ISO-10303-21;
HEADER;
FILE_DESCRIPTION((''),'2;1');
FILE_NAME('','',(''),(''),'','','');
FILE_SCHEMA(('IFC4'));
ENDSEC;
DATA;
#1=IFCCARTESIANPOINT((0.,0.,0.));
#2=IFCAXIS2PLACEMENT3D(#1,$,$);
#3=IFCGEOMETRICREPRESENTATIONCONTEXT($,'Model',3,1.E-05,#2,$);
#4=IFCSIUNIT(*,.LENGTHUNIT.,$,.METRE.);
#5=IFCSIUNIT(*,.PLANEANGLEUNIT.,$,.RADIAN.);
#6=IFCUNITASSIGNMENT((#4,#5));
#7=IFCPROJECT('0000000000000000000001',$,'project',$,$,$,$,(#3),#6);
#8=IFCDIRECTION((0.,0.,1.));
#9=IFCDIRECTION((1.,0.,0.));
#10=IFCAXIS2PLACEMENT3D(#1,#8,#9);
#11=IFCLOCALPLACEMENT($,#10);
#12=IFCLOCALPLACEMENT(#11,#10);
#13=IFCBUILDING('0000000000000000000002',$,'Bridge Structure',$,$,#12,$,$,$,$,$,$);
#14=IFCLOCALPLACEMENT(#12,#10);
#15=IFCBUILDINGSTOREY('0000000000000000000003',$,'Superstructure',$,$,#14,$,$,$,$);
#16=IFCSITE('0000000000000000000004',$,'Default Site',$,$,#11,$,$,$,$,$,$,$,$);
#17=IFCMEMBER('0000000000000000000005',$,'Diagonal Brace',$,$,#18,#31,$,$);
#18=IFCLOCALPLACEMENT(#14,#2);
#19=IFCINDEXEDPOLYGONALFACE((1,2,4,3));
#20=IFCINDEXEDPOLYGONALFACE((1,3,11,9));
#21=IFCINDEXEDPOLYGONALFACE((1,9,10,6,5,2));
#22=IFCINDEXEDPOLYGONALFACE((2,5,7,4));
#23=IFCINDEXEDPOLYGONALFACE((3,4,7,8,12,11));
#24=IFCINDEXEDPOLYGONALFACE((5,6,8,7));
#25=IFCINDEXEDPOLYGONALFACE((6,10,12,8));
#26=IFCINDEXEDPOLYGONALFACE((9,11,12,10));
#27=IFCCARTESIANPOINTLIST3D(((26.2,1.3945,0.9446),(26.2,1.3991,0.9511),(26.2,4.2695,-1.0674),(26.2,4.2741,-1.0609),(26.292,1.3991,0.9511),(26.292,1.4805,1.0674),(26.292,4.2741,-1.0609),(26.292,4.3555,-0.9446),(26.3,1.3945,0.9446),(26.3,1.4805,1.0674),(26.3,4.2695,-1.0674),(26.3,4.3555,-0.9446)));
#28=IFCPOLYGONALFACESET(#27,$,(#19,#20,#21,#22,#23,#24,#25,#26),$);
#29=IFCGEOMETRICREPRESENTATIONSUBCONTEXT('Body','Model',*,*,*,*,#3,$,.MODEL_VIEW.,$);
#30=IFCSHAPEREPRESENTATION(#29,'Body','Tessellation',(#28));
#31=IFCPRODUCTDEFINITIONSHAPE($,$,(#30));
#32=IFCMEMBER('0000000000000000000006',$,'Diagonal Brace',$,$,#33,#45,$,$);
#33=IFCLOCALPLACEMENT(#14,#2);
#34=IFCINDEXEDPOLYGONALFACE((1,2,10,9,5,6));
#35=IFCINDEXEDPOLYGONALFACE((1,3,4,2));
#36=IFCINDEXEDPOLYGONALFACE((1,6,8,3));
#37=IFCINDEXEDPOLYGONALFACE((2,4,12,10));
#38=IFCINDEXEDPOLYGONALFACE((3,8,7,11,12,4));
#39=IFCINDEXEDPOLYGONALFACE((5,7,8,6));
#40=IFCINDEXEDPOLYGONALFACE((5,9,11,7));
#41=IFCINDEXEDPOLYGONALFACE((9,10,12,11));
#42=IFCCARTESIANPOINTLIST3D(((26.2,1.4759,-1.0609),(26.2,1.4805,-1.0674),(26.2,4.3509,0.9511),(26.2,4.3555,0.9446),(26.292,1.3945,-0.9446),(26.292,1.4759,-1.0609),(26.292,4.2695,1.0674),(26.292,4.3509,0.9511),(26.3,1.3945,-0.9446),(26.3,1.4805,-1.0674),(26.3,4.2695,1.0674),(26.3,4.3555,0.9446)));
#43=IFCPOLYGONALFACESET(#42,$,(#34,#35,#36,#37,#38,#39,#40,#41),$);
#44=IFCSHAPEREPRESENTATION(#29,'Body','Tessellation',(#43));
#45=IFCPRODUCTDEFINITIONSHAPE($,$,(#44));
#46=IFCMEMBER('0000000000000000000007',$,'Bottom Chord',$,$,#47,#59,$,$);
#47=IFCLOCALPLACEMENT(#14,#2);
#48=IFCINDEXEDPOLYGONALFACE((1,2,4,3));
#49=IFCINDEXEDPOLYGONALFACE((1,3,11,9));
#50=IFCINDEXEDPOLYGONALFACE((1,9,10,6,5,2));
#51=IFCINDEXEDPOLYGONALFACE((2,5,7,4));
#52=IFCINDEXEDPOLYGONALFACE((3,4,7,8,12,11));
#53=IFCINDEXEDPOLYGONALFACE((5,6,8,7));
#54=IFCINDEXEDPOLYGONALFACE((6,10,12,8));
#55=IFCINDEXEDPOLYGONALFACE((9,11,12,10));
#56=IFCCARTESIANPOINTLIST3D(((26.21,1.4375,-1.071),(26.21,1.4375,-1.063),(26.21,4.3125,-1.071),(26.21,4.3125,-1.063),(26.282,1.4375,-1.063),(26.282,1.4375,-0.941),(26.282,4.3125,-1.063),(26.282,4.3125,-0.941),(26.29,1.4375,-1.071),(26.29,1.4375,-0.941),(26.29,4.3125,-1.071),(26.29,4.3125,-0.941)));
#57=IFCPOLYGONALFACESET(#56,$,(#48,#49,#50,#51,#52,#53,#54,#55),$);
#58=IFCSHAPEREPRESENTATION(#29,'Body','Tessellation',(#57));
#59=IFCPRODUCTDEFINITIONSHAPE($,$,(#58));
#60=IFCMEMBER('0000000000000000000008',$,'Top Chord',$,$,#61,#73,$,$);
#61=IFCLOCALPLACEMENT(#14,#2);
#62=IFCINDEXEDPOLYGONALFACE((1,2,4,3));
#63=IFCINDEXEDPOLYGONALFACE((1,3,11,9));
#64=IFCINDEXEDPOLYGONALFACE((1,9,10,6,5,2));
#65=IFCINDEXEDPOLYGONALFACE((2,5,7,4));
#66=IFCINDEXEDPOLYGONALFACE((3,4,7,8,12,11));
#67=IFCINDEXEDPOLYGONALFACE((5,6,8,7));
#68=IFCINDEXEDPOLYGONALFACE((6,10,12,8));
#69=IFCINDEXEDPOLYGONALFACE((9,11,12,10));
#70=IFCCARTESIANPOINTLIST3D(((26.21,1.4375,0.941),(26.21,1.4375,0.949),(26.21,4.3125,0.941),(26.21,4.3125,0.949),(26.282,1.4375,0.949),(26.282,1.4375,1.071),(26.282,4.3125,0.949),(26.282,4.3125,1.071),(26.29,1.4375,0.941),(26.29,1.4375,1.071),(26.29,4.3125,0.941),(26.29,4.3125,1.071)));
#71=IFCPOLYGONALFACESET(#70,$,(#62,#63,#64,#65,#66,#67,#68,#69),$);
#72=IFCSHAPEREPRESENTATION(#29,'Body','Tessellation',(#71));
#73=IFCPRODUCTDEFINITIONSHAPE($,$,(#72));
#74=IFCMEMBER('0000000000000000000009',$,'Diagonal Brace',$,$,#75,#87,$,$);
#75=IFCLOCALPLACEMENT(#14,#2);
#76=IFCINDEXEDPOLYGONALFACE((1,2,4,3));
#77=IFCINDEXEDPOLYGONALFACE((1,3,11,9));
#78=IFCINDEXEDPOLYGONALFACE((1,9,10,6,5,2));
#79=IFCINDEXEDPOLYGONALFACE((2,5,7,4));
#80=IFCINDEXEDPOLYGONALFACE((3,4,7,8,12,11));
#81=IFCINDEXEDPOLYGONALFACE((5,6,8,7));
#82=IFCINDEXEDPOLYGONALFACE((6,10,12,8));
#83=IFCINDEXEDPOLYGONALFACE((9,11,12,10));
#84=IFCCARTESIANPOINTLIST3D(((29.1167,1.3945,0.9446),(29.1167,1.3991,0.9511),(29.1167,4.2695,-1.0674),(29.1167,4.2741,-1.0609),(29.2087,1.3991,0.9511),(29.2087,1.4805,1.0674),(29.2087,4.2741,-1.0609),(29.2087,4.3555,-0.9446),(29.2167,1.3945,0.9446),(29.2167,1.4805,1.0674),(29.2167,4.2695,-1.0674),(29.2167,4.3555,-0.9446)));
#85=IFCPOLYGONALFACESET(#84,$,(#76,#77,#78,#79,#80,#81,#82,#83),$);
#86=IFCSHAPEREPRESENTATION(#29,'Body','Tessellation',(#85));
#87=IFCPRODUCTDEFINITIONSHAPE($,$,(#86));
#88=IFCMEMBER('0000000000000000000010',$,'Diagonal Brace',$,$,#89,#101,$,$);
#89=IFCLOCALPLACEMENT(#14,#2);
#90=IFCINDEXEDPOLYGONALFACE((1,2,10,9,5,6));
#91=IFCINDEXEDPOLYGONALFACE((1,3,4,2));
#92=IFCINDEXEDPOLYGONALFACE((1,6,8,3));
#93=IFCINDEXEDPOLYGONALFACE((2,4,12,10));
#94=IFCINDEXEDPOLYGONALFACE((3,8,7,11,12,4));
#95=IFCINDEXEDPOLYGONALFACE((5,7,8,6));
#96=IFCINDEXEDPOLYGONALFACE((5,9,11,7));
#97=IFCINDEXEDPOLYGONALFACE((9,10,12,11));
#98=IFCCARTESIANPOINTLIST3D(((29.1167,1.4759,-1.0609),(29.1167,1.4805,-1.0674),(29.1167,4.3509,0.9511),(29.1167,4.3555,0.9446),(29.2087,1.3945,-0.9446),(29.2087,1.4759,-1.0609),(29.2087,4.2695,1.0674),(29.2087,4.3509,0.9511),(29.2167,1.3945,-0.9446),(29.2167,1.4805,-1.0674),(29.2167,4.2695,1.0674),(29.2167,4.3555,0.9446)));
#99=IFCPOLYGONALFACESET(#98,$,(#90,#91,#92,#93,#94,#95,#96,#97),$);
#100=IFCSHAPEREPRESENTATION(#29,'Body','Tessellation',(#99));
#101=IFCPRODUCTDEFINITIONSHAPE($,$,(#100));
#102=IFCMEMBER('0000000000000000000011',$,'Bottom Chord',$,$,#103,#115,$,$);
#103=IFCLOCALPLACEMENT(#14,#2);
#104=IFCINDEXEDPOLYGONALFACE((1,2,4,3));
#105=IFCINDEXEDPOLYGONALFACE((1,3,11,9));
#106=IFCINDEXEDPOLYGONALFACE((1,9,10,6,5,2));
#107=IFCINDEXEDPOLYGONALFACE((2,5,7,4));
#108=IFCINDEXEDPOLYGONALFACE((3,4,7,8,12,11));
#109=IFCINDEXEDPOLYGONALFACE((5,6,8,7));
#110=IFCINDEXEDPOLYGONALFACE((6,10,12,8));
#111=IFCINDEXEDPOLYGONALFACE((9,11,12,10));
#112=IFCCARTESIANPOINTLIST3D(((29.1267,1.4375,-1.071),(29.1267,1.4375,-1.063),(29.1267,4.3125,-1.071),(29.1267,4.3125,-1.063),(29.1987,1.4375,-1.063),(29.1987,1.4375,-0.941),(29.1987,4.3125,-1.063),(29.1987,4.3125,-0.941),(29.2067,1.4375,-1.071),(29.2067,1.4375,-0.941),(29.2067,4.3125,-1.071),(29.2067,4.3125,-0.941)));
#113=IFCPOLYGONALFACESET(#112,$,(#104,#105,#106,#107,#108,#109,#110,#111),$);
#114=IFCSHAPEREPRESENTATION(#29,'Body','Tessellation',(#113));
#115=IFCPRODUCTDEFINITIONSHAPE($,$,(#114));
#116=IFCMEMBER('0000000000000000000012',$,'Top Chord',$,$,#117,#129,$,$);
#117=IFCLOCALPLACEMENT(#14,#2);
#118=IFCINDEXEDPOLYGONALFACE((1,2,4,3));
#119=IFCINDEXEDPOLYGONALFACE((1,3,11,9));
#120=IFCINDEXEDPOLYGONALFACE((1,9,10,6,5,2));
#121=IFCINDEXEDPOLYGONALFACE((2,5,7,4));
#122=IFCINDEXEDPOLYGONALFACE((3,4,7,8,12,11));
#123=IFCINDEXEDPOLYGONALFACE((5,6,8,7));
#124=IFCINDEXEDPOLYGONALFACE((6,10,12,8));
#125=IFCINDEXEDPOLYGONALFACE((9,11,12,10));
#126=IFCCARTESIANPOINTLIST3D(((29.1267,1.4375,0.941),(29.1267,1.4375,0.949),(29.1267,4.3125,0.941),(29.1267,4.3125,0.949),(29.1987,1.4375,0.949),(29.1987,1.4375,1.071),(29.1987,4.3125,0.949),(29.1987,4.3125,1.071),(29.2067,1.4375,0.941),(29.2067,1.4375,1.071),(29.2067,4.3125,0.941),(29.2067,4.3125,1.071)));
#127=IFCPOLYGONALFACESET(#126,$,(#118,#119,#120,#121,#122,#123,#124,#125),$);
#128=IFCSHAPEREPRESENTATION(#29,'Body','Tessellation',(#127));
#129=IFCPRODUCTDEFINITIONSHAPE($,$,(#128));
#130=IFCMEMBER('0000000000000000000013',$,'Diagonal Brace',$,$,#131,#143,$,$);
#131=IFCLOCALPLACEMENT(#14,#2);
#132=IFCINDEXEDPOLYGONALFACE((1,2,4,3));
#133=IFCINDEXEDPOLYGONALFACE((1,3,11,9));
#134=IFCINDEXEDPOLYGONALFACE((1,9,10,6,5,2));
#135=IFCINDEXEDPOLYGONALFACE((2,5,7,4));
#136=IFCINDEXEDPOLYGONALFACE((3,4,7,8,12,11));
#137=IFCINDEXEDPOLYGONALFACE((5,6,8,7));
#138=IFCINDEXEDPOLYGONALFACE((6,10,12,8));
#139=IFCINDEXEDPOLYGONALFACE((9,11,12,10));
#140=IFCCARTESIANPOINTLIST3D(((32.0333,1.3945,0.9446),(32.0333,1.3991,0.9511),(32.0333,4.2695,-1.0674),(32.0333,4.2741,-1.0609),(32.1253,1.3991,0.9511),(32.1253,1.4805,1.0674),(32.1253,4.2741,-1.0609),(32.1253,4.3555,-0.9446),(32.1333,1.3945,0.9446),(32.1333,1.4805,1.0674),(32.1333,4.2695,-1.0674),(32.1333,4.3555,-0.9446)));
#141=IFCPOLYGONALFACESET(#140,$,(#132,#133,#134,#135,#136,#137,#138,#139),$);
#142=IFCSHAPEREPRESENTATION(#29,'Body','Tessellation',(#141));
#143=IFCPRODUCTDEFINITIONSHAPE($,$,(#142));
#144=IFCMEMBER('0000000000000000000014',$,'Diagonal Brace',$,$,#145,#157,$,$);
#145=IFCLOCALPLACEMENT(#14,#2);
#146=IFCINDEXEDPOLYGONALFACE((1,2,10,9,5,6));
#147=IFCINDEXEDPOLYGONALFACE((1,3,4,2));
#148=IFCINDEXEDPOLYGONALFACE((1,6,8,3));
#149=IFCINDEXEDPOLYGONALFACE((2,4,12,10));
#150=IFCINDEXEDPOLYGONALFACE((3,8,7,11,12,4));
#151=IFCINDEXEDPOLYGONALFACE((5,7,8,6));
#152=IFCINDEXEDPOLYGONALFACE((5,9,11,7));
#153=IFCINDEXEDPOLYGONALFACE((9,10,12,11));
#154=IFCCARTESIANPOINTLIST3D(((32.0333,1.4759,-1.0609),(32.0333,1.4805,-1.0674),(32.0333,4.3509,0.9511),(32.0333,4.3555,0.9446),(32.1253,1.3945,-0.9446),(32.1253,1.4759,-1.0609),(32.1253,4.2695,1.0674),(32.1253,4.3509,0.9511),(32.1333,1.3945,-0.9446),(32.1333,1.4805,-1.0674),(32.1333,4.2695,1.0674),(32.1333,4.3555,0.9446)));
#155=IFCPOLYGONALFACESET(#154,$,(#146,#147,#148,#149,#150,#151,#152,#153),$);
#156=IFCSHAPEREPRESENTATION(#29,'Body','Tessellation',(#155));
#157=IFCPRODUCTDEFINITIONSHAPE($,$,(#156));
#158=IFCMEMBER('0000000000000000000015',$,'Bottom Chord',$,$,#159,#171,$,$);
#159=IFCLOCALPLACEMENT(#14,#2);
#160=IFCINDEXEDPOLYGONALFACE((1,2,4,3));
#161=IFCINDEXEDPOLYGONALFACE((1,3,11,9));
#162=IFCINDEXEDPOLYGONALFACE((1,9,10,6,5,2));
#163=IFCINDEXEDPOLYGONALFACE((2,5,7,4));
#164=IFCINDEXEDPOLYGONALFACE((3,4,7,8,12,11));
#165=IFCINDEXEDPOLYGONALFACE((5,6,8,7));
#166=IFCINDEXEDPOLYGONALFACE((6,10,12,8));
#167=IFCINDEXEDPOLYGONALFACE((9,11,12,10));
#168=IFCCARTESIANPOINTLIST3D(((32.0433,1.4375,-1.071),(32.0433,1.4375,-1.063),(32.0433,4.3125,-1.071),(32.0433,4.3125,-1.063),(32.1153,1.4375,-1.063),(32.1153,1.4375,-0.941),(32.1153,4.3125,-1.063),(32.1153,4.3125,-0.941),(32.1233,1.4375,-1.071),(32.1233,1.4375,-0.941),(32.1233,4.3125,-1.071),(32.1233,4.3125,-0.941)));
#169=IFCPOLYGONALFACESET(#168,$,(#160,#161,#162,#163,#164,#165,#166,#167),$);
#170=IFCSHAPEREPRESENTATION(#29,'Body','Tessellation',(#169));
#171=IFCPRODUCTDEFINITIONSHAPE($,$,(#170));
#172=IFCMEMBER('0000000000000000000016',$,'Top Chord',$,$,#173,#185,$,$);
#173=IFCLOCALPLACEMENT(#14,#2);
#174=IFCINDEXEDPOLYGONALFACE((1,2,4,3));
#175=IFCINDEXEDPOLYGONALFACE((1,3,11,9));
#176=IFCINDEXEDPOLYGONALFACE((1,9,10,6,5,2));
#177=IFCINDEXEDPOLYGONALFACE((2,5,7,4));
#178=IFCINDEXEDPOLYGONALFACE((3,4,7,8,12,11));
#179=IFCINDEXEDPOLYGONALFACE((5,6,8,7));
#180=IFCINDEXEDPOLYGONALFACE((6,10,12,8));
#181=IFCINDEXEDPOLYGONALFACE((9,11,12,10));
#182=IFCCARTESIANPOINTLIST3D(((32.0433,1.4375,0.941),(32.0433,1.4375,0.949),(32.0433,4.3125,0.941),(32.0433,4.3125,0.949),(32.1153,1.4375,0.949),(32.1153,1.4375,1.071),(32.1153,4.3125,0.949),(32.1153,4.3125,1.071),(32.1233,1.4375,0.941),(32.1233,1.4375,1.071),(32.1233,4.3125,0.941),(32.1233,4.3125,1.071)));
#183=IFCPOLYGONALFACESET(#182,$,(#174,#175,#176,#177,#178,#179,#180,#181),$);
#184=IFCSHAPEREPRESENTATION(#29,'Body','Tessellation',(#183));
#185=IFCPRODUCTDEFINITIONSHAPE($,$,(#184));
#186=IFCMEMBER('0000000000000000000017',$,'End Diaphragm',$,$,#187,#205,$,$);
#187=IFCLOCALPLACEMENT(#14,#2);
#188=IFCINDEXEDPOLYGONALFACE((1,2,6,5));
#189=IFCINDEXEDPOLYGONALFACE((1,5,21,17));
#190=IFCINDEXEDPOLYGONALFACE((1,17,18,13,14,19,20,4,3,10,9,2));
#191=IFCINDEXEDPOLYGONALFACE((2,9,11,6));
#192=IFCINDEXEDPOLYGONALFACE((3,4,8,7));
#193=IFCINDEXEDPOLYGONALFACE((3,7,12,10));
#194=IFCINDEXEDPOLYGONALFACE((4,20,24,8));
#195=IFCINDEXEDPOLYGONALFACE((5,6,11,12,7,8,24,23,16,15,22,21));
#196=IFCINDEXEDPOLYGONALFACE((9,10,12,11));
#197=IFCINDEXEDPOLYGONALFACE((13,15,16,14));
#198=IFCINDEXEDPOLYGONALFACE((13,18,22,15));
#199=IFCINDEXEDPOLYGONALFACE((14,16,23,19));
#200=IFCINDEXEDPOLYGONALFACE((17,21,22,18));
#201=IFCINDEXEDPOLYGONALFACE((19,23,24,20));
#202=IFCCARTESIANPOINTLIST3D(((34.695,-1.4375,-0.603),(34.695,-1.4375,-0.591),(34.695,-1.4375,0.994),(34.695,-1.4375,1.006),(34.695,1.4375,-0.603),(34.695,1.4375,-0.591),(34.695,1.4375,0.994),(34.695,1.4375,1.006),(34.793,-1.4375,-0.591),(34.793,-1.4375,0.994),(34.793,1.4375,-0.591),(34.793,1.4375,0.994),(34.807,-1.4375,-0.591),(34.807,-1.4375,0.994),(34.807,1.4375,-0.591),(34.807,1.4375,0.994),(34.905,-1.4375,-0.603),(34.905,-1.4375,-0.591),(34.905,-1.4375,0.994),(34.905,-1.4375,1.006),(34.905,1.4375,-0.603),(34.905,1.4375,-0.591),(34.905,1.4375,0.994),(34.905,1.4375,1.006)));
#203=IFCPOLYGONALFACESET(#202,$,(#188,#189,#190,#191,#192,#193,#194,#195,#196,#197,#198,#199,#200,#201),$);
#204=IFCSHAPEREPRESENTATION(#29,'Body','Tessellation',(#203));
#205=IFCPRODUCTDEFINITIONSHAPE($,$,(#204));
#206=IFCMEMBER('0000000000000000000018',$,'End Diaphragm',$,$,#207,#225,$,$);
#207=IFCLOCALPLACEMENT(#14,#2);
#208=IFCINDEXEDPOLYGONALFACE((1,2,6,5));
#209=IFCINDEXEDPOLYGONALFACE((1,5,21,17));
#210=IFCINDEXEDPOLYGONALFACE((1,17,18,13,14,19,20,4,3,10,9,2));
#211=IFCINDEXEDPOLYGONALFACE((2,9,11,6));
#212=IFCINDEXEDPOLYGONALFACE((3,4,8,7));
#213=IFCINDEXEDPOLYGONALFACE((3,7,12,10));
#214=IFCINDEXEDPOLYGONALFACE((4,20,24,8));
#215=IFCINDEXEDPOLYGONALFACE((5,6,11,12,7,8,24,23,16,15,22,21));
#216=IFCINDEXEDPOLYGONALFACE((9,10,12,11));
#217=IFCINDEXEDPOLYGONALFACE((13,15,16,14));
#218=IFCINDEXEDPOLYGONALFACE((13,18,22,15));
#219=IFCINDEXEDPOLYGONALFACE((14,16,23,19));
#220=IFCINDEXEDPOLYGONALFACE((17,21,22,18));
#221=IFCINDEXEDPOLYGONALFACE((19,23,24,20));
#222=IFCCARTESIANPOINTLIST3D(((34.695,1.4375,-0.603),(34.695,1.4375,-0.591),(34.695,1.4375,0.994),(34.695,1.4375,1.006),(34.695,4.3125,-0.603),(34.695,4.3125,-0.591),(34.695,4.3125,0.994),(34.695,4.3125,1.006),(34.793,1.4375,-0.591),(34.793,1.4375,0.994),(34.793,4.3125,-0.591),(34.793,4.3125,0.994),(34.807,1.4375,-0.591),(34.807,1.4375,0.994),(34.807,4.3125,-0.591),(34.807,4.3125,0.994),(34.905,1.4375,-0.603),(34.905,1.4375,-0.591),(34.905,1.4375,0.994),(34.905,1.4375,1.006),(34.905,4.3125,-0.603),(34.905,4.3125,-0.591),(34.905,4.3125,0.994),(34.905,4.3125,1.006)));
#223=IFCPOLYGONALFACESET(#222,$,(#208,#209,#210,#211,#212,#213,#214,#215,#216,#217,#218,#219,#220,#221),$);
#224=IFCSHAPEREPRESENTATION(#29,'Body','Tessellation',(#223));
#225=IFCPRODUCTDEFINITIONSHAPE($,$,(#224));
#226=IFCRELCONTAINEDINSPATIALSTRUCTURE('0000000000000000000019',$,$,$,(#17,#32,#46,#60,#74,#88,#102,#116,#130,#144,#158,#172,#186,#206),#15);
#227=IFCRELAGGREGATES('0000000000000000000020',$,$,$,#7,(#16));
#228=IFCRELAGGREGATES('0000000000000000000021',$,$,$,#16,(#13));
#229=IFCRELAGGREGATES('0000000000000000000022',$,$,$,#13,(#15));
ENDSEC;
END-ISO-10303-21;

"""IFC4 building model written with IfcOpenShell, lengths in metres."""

from ifc_helpers import new_model, si_unit, frame, origin, origin_with_axes, origin_2d_with_axis, place, context, subcontext, project, spatial, i_section, l_section, extrude, element, save


model = new_model("IFC4")

# Units and contexts
model_context = context("Model", 3, precision=1e-05, world=origin())
body_context = subcontext(model_context, "Body", "Model", "MODEL_VIEW")
ifc_project = project(units=[si_unit("LENGTHUNIT", "METRE"), si_unit("PLANEANGLEUNIT", "RADIAN")], contexts=[model_context])

# Site, building, storey
site_placement = place(None, origin_with_axes())
site = spatial("IfcSite", under=ifc_project, at=site_placement, Name="Default Site")
building_placement = place(site_placement, origin_with_axes())
building = spatial("IfcBuilding", under=site, at=building_placement, Name="Bridge Structure")
storey_placement = place(building_placement, origin_with_axes())
storey = spatial("IfcBuildingStorey", under=building, at=storey_placement, Name="Superstructure")

# Members
for number, where, z_axis, x_axis, name in (
    (1, (26.25, 1.4375, 1.006), (0.0, 0.819299, -0.573367), (-1.0, 0.0, 0.0), "Diagonal Brace"),
    (2, (26.25, 1.4375, -1.006), (0.0, 0.819299, 0.573367), (-1.0, 0.0, 0.0), "Diagonal Brace"),
):
    element("IfcMember", number, at=place(storey_placement, frame(where, z_axis=z_axis, x_axis=x_axis)), inside=storey, Name=name, context=body_context, shape_type="SweptSolid", body=[
        extrude(l_section(Depth=0.15, Width=0.1, Thickness=0.008, at=origin_2d_with_axis()), origin_with_axes(), (0.0, 0.0, 1.0), 3.5091),
    ])
for number, where, z_axis, x_axis, name in (
    (3, (26.25, 1.4375, -1.006), (0.0, 1.0, 0.0), (-1.0, 0.0, 0.0), "Bottom Chord"),
    (4, (26.25, 1.4375, 1.006), (0.0, 1.0, 0.0), (-1.0, 0.0, 0.0), "Top Chord"),
):
    element("IfcMember", number, at=place(storey_placement, frame(where, z_axis=z_axis, x_axis=x_axis)), inside=storey, Name=name, context=body_context, shape_type="SweptSolid", body=[
        extrude(l_section(Depth=0.13, Width=0.08, Thickness=0.008, at=origin_2d_with_axis()), origin_with_axes(), (0.0, 0.0, 1.0), 2.875),
    ])
for number, where, z_axis, x_axis, name in (
    (5, (29.1667, 1.4375, 1.006), (0.0, 0.819299, -0.573367), (-1.0, 0.0, 0.0), "Diagonal Brace"),
    (6, (29.1667, 1.4375, -1.006), (0.0, 0.819299, 0.573367), (-1.0, 0.0, 0.0), "Diagonal Brace"),
):
    element("IfcMember", number, at=place(storey_placement, frame(where, z_axis=z_axis, x_axis=x_axis)), inside=storey, Name=name, context=body_context, shape_type="SweptSolid", body=[
        extrude(l_section(Depth=0.15, Width=0.1, Thickness=0.008, at=origin_2d_with_axis()), origin_with_axes(), (0.0, 0.0, 1.0), 3.5091),
    ])
for number, where, z_axis, x_axis, name in (
    (7, (29.1667, 1.4375, -1.006), (0.0, 1.0, 0.0), (-1.0, 0.0, 0.0), "Bottom Chord"),
    (8, (29.1667, 1.4375, 1.006), (0.0, 1.0, 0.0), (-1.0, 0.0, 0.0), "Top Chord"),
):
    element("IfcMember", number, at=place(storey_placement, frame(where, z_axis=z_axis, x_axis=x_axis)), inside=storey, Name=name, context=body_context, shape_type="SweptSolid", body=[
        extrude(l_section(Depth=0.13, Width=0.08, Thickness=0.008, at=origin_2d_with_axis()), origin_with_axes(), (0.0, 0.0, 1.0), 2.875),
    ])
for number, where, z_axis, x_axis, name in (
    (9, (32.0833, 1.4375, 1.006), (0.0, 0.819299, -0.573367), (-1.0, 0.0, 0.0), "Diagonal Brace"),
    (10, (32.0833, 1.4375, -1.006), (0.0, 0.819299, 0.573367), (-1.0, 0.0, 0.0), "Diagonal Brace"),
):
    element("IfcMember", number, at=place(storey_placement, frame(where, z_axis=z_axis, x_axis=x_axis)), inside=storey, Name=name, context=body_context, shape_type="SweptSolid", body=[
        extrude(l_section(Depth=0.15, Width=0.1, Thickness=0.008, at=origin_2d_with_axis()), origin_with_axes(), (0.0, 0.0, 1.0), 3.5091),
    ])
for number, where, z_axis, x_axis, name in (
    (11, (32.0833, 1.4375, -1.006), (0.0, 1.0, 0.0), (-1.0, 0.0, 0.0), "Bottom Chord"),
    (12, (32.0833, 1.4375, 1.006), (0.0, 1.0, 0.0), (-1.0, 0.0, 0.0), "Top Chord"),
):
    element("IfcMember", number, at=place(storey_placement, frame(where, z_axis=z_axis, x_axis=x_axis)), inside=storey, Name=name, context=body_context, shape_type="SweptSolid", body=[
        extrude(l_section(Depth=0.13, Width=0.08, Thickness=0.008, at=origin_2d_with_axis()), origin_with_axes(), (0.0, 0.0, 1.0), 2.875),
    ])
for number, where, z_axis, x_axis, name in (
    (13, (34.8, -1.4375, 0.2015), (0.0, 1.0, 0.0), (-1.0, 0.0, 0.0), "End Diaphragm"),
    (14, (34.8, 1.4375, 0.2015), (0.0, 1.0, 0.0), (-1.0, 0.0, 0.0), "End Diaphragm"),
):
    element("IfcMember", number, at=place(storey_placement, frame(where, z_axis=z_axis, x_axis=x_axis)), inside=storey, Name=name, context=body_context, shape_type="SweptSolid", body=[
        extrude(i_section(OverallWidth=0.21, OverallDepth=1.609, WebThickness=0.014, FlangeThickness=0.012, at=origin_2d_with_axis()), origin_with_axes(), (0.0, 0.0, 1.0), 2.875),
    ])

save(model, "model.ifc")
